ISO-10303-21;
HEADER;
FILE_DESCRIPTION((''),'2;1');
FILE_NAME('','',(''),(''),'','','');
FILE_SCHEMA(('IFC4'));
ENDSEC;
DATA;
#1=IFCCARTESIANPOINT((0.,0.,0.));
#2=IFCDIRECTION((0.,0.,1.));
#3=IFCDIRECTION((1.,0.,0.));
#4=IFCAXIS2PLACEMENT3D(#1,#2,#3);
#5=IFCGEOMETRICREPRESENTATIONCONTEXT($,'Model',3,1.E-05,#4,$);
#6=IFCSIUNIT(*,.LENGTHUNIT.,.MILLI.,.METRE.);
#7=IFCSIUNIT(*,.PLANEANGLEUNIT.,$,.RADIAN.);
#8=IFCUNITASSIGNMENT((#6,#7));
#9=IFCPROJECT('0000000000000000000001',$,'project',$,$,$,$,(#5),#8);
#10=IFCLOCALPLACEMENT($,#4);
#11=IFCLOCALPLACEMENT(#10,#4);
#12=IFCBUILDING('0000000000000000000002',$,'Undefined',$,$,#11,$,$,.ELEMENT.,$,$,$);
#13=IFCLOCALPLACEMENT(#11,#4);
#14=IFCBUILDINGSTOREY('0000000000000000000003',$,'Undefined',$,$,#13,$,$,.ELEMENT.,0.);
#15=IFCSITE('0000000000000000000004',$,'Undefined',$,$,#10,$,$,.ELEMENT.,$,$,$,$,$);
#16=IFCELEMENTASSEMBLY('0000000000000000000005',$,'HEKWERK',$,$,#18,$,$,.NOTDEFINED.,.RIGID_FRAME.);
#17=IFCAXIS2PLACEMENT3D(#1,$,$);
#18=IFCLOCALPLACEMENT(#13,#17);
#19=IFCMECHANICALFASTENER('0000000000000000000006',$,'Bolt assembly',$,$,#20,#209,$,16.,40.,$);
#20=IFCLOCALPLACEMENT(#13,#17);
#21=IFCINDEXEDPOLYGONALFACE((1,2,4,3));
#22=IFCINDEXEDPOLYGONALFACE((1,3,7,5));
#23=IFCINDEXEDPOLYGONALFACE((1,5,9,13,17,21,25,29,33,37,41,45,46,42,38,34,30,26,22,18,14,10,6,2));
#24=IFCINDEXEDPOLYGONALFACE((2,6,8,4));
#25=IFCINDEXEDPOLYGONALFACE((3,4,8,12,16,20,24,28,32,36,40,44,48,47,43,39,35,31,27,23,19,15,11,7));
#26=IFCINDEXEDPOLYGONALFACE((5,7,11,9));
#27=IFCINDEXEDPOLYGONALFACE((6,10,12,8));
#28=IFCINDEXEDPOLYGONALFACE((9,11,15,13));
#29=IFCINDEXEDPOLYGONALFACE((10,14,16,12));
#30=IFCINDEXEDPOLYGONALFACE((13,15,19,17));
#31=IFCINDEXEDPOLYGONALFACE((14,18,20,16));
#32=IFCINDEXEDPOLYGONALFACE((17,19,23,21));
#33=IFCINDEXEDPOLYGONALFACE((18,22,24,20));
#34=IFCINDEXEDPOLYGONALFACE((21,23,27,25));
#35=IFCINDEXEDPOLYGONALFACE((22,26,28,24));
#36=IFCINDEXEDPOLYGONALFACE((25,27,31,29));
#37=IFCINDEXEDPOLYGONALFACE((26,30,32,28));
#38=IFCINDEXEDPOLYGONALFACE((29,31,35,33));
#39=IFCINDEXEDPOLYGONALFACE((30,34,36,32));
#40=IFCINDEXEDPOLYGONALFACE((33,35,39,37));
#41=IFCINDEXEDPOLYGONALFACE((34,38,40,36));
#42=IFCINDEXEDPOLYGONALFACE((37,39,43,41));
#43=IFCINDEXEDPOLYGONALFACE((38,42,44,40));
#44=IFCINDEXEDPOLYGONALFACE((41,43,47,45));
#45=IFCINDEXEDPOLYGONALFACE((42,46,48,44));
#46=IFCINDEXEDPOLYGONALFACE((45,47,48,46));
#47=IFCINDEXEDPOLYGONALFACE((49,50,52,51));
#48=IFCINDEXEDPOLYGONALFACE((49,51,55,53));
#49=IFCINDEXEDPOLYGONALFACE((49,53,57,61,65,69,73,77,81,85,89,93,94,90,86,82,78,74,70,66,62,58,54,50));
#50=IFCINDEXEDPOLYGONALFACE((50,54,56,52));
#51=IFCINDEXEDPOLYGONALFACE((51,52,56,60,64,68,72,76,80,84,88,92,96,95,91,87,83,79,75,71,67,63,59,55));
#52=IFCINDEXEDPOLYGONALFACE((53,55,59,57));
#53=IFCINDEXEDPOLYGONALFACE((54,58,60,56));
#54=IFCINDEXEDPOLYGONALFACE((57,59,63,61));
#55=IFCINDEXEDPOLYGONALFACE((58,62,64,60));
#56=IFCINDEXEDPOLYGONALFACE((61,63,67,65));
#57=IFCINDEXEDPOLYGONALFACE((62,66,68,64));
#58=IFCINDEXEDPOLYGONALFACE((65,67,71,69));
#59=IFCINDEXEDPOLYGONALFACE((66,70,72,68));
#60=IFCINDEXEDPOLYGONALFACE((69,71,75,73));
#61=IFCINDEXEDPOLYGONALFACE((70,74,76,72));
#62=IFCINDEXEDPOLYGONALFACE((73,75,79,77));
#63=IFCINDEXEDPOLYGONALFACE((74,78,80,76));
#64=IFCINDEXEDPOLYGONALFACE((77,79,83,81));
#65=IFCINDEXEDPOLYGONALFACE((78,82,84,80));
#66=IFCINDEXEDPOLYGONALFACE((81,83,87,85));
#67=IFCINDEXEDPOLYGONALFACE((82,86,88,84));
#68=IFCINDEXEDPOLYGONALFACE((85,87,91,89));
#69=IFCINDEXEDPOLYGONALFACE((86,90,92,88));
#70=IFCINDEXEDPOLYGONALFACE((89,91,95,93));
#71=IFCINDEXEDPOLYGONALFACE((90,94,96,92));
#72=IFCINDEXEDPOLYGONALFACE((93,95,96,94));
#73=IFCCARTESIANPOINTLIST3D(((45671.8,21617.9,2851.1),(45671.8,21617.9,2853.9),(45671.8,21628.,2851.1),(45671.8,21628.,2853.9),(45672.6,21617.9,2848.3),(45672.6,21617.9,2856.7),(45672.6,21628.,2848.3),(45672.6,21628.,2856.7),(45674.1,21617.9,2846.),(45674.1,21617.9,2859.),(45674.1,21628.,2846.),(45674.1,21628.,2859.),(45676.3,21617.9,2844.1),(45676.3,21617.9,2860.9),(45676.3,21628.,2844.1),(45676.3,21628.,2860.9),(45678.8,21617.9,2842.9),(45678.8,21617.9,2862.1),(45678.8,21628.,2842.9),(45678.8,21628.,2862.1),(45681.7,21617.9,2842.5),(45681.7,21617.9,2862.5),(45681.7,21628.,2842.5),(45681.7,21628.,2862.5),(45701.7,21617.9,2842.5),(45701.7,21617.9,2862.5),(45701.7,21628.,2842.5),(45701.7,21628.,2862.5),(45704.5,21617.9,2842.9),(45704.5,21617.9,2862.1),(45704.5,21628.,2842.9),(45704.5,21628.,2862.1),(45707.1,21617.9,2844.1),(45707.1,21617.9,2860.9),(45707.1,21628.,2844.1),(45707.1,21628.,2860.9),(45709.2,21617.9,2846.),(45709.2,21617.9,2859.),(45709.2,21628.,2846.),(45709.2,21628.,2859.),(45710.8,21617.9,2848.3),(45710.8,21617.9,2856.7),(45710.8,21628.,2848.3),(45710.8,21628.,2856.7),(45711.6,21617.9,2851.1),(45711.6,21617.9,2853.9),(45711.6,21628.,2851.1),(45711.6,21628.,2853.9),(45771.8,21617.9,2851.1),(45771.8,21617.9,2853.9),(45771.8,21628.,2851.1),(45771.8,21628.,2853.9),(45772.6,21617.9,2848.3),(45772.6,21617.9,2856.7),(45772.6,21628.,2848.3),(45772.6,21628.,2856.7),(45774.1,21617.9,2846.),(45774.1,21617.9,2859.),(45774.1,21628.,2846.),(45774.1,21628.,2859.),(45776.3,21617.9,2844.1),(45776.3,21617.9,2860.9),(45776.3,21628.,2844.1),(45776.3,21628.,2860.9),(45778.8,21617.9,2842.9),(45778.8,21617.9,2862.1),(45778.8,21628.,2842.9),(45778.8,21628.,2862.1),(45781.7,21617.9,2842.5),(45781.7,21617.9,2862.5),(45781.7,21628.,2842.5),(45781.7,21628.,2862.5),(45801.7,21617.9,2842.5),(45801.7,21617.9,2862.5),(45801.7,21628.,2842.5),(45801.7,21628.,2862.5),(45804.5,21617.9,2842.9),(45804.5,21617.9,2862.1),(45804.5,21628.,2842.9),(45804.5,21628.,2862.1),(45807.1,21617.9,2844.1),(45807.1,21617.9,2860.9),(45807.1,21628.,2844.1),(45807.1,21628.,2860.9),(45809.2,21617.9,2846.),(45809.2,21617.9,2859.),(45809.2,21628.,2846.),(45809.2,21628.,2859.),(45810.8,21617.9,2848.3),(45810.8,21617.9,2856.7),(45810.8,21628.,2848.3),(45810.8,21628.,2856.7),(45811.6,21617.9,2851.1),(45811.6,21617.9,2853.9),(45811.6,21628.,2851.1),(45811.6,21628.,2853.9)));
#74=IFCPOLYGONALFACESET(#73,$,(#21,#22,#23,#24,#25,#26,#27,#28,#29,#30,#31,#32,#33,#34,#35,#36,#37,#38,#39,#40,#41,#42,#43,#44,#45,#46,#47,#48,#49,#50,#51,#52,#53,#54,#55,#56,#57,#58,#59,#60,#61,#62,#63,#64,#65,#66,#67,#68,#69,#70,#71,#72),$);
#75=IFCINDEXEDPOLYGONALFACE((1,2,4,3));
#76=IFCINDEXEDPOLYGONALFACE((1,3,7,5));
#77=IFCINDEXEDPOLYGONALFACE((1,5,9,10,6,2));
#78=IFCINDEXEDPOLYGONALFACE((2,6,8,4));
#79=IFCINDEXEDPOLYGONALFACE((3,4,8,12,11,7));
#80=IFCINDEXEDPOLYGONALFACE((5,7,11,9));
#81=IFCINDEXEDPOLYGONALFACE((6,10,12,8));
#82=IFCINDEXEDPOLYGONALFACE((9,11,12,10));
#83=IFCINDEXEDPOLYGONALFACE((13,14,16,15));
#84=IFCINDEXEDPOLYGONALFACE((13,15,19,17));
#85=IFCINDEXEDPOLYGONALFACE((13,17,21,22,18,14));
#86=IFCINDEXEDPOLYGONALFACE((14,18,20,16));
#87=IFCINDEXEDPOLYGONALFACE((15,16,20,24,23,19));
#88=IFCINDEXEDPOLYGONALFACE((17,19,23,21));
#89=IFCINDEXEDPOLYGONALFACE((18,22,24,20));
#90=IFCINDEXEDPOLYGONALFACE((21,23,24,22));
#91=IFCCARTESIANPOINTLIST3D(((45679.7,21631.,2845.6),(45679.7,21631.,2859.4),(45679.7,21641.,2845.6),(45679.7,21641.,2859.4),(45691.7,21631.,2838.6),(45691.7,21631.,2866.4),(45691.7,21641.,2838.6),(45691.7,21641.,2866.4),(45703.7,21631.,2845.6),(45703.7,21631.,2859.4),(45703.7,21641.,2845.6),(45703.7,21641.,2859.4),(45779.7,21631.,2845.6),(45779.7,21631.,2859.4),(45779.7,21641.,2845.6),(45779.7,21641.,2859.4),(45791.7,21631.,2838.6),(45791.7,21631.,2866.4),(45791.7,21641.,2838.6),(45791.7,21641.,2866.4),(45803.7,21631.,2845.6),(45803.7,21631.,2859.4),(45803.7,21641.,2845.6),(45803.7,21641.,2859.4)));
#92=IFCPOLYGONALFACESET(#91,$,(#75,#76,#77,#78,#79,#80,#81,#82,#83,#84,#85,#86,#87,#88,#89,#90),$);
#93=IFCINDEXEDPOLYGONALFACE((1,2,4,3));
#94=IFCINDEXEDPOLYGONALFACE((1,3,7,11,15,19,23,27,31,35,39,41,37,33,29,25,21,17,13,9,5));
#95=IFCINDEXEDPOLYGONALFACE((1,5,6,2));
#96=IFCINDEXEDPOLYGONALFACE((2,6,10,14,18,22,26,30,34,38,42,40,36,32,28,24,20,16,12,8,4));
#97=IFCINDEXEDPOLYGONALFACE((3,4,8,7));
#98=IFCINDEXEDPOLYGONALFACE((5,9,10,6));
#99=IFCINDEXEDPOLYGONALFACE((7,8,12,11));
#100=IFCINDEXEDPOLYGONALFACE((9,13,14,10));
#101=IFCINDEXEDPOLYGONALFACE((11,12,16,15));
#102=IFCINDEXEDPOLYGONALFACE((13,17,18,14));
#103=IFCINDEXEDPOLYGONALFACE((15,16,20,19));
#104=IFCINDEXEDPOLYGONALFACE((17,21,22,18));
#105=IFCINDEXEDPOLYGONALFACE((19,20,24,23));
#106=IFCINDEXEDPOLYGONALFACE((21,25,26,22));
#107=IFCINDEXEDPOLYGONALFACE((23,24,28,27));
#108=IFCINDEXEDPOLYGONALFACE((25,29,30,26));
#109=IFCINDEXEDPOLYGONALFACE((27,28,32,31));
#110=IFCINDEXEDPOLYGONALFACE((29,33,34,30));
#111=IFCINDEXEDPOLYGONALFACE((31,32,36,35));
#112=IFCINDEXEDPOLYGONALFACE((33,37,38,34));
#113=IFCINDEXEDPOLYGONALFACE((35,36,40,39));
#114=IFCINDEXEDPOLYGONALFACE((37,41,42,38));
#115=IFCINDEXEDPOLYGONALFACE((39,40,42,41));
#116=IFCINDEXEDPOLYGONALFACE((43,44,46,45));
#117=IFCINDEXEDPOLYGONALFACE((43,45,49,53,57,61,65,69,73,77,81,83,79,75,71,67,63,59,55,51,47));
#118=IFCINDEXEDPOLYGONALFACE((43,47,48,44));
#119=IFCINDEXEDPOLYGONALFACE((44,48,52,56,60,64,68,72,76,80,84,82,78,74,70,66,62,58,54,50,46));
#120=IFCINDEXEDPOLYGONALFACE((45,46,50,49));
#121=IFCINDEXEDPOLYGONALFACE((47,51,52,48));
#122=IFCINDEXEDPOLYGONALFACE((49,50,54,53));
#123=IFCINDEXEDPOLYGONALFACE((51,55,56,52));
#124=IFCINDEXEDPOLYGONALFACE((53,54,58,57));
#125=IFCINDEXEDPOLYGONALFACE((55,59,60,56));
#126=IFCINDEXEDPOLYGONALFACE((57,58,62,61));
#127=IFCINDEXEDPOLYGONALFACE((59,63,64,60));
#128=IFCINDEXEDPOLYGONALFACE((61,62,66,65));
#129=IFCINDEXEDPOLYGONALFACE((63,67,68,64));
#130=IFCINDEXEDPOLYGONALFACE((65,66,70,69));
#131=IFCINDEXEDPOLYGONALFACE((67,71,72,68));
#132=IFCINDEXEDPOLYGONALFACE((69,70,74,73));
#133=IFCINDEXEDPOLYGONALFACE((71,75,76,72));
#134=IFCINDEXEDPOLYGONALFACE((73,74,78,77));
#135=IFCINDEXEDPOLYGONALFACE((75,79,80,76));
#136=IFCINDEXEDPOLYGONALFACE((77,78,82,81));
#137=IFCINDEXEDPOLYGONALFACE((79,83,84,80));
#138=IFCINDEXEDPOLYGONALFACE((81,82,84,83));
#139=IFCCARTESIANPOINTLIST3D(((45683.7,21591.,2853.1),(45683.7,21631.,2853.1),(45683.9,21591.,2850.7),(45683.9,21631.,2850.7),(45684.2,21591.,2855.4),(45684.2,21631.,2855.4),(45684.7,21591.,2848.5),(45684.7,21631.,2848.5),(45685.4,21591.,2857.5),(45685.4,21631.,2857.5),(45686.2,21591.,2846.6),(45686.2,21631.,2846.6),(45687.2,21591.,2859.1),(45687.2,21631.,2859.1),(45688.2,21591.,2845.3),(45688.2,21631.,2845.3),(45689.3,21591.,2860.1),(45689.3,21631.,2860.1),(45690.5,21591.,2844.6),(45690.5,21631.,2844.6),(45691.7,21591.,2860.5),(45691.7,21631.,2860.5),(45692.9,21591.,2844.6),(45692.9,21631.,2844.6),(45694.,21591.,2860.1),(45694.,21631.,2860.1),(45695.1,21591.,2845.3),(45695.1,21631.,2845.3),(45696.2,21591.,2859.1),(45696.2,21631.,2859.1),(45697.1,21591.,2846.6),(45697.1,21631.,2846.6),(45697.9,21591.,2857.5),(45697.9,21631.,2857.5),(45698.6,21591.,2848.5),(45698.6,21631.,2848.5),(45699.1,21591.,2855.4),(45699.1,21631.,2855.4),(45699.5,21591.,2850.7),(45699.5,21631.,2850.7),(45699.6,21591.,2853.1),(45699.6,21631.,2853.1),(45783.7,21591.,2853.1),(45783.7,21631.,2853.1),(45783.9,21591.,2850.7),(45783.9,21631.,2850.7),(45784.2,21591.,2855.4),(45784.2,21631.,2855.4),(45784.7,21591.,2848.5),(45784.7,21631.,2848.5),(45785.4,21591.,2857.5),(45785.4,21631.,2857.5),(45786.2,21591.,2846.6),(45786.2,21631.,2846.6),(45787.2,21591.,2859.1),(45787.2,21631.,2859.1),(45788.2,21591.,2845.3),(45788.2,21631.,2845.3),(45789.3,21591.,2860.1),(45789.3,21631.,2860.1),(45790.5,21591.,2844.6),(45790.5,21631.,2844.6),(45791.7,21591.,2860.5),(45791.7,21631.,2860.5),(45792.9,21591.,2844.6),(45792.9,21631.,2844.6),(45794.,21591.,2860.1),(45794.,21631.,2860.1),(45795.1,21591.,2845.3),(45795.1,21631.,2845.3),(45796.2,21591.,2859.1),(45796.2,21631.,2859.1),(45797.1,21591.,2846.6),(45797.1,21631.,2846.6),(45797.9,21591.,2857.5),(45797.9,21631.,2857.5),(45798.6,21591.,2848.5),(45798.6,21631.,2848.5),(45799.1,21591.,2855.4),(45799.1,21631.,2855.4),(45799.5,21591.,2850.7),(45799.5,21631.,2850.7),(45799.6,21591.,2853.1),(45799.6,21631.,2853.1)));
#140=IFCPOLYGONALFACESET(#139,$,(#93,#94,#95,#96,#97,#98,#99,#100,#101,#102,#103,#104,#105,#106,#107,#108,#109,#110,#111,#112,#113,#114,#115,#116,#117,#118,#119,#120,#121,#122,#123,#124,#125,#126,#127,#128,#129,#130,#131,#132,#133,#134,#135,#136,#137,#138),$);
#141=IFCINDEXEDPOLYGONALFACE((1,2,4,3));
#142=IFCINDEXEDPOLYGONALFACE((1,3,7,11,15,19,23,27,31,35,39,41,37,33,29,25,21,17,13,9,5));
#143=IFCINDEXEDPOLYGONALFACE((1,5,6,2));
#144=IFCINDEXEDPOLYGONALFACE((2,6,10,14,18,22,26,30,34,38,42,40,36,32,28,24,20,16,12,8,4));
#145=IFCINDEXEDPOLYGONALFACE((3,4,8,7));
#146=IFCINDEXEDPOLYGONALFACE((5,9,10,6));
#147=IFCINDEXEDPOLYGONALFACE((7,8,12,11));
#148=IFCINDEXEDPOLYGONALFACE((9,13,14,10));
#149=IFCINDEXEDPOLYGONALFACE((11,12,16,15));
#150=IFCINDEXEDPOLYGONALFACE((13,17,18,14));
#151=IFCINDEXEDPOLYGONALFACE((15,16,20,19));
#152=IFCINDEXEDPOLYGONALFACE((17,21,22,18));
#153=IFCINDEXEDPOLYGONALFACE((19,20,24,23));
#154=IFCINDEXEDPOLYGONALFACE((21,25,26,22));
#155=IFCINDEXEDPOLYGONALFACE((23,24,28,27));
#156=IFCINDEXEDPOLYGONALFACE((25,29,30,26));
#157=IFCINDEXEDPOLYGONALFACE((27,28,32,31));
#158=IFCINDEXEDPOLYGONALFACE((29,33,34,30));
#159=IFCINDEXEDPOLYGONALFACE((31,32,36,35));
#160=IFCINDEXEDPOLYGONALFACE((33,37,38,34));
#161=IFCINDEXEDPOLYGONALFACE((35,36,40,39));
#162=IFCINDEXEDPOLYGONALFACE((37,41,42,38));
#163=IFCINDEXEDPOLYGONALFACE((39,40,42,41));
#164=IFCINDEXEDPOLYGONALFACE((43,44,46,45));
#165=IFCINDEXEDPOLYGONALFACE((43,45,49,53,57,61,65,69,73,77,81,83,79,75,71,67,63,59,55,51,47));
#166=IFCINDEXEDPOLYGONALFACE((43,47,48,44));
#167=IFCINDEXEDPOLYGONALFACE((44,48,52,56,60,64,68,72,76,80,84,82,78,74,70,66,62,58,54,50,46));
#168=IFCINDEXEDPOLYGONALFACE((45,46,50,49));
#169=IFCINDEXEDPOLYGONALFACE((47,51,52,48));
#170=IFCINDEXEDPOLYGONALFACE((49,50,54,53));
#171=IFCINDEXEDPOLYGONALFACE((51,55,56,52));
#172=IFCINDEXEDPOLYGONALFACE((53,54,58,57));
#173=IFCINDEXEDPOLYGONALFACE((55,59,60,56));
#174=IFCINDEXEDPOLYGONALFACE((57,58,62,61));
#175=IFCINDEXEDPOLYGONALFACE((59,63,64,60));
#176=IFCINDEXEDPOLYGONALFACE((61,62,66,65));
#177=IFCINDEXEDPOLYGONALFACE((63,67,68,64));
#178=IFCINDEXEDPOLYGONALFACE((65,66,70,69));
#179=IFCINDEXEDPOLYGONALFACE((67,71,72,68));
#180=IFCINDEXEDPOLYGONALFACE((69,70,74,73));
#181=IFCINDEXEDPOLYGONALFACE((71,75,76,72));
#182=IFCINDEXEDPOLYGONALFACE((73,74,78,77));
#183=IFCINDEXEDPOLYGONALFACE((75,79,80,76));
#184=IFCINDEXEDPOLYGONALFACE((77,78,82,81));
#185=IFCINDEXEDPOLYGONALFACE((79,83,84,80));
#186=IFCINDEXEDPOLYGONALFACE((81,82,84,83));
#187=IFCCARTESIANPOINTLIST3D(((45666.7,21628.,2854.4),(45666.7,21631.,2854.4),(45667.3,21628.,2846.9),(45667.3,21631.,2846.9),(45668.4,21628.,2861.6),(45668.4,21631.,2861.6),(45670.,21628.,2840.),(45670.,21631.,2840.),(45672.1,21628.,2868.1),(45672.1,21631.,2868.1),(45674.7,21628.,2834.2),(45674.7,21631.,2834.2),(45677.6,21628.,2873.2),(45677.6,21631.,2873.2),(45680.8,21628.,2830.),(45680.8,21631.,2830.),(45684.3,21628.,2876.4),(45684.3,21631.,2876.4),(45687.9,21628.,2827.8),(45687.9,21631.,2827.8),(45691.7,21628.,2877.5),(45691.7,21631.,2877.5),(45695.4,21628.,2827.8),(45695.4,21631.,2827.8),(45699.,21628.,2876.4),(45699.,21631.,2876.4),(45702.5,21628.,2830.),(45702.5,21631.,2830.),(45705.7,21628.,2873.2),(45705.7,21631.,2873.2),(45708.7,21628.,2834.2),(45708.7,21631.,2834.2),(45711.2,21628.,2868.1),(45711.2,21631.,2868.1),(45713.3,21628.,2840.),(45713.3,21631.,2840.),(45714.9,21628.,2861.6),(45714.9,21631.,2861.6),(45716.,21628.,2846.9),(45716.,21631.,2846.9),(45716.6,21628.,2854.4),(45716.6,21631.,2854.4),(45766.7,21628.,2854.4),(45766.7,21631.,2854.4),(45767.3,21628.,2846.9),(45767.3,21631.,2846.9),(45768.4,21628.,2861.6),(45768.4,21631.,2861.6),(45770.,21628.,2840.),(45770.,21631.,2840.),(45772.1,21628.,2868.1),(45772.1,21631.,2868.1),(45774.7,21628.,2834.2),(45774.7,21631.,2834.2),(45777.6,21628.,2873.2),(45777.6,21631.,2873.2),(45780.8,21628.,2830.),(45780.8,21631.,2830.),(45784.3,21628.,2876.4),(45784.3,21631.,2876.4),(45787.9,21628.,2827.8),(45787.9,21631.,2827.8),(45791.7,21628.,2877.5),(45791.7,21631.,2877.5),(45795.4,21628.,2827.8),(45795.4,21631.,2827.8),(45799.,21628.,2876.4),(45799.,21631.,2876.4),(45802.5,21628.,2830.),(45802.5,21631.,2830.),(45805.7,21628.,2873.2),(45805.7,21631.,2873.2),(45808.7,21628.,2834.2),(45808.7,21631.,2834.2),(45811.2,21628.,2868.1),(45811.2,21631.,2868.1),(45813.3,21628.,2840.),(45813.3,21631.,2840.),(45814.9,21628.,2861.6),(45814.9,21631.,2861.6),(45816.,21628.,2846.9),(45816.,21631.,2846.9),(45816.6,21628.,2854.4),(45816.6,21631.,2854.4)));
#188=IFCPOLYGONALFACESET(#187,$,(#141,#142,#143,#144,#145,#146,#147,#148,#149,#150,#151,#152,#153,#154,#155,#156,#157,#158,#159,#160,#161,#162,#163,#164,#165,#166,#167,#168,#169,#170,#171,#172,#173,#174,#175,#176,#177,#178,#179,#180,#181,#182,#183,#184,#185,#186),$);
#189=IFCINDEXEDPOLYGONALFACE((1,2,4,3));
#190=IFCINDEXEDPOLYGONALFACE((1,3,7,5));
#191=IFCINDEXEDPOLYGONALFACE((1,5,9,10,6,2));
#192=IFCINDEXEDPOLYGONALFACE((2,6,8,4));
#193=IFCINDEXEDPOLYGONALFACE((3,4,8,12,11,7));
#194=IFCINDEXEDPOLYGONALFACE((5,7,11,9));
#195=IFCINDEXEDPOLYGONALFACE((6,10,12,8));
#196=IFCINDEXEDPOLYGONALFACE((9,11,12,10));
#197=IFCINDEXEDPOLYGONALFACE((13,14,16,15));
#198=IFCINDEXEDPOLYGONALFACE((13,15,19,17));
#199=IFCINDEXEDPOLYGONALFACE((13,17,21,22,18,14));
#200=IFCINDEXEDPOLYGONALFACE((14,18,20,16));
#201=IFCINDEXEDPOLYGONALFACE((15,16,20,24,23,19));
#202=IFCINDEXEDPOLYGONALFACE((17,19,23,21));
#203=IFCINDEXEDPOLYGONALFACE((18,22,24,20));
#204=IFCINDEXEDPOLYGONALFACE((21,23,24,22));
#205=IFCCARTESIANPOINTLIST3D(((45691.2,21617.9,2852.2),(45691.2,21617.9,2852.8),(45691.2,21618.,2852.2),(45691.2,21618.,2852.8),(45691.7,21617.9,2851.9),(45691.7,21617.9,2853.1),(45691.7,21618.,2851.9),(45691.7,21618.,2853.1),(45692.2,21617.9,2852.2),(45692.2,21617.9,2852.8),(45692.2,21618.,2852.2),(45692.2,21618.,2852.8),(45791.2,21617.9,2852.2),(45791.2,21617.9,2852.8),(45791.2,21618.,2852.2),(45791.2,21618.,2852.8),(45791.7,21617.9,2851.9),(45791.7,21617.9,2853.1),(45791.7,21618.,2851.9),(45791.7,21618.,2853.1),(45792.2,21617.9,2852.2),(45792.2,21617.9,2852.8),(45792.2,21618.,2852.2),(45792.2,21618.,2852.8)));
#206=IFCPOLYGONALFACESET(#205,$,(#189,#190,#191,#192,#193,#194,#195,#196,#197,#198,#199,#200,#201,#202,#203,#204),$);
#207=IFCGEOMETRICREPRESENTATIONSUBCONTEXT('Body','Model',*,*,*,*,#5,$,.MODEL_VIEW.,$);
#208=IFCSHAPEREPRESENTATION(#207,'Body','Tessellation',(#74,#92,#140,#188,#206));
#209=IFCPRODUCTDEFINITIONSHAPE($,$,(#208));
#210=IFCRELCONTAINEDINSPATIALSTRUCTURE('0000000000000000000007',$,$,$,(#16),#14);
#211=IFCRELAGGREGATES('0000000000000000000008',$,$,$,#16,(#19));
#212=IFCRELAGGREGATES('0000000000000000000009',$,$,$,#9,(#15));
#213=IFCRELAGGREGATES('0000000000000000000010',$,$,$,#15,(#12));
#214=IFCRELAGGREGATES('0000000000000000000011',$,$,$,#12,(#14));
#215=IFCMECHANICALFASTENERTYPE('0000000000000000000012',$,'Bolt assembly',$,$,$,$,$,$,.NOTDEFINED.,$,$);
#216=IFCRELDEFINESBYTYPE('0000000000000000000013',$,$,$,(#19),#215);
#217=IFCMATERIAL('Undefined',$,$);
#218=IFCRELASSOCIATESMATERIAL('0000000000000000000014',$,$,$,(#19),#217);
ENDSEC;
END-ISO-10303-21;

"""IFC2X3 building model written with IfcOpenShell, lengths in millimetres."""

from ifc_helpers import new_model, si_unit, frame, frame_2d, origin_with_axes, origin_2d_with_axis, place, context, subcontext, project, spatial, polyline, circle_curve, parameter, trimmed, segment, composite_curve, circle, outline, extrude, source, transform, mapped, material, type_object, element, aggregate, save


model = new_model("IFC2X3")

# Units and contexts
model_context = context("Model", 3, precision=1e-05, world=origin_with_axes())
body_context = subcontext(model_context, "Body", "Model", "MODEL_VIEW")
ifc_project = project(units=[si_unit("LENGTHUNIT", "METRE", prefix="MILLI"), si_unit("PLANEANGLEUNIT", "RADIAN")], contexts=[model_context])

# Site, building, storey
site_placement = place(None, origin_with_axes())
site = spatial("IfcSite", under=ifc_project, at=site_placement, Name="Undefined", CompositionType="ELEMENT")
building_placement = place(site_placement, origin_with_axes())
building = spatial("IfcBuilding", under=site, at=building_placement, Name="Undefined", CompositionType="ELEMENT")
storey_placement = place(building_placement, origin_with_axes())
storey = spatial("IfcBuildingStorey", under=building, at=storey_placement, Name="Undefined", CompositionType="ELEMENT", Elevation=0.0)

# Element assembly
assembly_1_placement = place(storey_placement, origin_with_axes())
assembly_1 = element("IfcElementAssembly", 1, at=assembly_1_placement, inside=storey, Name="HEKWERK", AssemblyPlace="NOTDEFINED", PredefinedType="RIGID_FRAME")

# Mechanical fastener
ifc_material_1 = material(Name="Undefined")
mechanical_fastener_type = type_object("IfcMechanicalFastenerType", Name="Bolt assembly")
shared_shape_1 = source(origin_with_axes(), body_context, "Body", "SweptSolid", [
    extrude(outline(composite_curve([segment(polyline([(10.0, 10.0), (10.0, -10.0)]), True, "CONTINUOUS"), segment(trimmed(circle_curve(frame_2d((0.0, -10.0), x_axis=(1.0, 0.0)), 10.0), [parameter(0.0)], [parameter(3.141593)], False, "PARAMETER"), True, "CONTINUOUS"), segment(polyline([(-10.0, -10.0), (-10.0, 10.0)]), True, "CONTINUOUS"), segment(trimmed(circle_curve(frame_2d((0.0, 10.0), x_axis=(-1.0, 0.0)), 10.0), [parameter(0.0)], [parameter(3.141593)], False, "PARAMETER"), True, "DISCONTINUOUS")], self_intersect=False)), frame((0.0, 30.0, 0.0), z_axis=(0.0, 1.0, 0.0), x_axis=(1.0, 0.0, 0.0)), (0.0, 0.0, 1.0), 10.1),
    extrude(outline(polyline([(13.9, 0.0), (6.9, 12.0), (-6.9, 12.0), (-13.9, 0.0), (-6.9, -12.0), (6.9, -12.0), (13.9, 0.0)])), frame((0.0, 17.0, 0.0), z_axis=(0.0, 1.0, 0.0), x_axis=(1.0, 0.0, 0.0)), (0.0, 0.0, 1.0), 10.0),
    extrude(circle(Radius=8.0, at=origin_2d_with_axis()), frame((0.0, 27.0, 0.0), z_axis=(0.0, 1.0, 0.0), x_axis=(1.0, 0.0, 0.0)), (0.0, 0.0, 1.0), 40.0),
    extrude(circle(Radius=25.0, at=origin_2d_with_axis()), frame((0.0, 27.0, 0.0), z_axis=(0.0, 1.0, 0.0), x_axis=(1.0, 0.0, 0.0)), (0.0, 0.0, 1.0), 3.0),
    extrude(outline(polyline([(0.6, 0.0), (0.3, 0.5), (-0.3, 0.5), (-0.6, 0.0), (-0.3, -0.5), (0.3, -0.5), (0.6, 0.0)])), frame((0.0, 40.0, 0.0), z_axis=(0.0, 1.0, 0.0), x_axis=(1.0, 0.0, 0.0)), (0.0, 0.0, 1.0), 0.1),
])
mechanical_fastener_1_placement = place(assembly_1_placement, frame((45741.7, 21658.0, 2852.5), z_axis=(1.0, 0.0, 0.0), x_axis=(0.0, 0.0, 1.0)))
mechanical_fastener_1 = element("IfcMechanicalFastener", 2, at=mechanical_fastener_1_placement, type_object=mechanical_fastener_type, material=ifc_material_1, Name="Bolt assembly", NominalDiameter=16.0, NominalLength=40.0, context=body_context, shape_type="MappedRepresentation", body=[
    mapped(shared_shape_1, transform((0.0, 0.0, -50.0))),
    mapped(shared_shape_1, transform((0.0, 0.0, 50.0))),
])
aggregate(assembly_1, [mechanical_fastener_1])

save(model, "model.ifc")
